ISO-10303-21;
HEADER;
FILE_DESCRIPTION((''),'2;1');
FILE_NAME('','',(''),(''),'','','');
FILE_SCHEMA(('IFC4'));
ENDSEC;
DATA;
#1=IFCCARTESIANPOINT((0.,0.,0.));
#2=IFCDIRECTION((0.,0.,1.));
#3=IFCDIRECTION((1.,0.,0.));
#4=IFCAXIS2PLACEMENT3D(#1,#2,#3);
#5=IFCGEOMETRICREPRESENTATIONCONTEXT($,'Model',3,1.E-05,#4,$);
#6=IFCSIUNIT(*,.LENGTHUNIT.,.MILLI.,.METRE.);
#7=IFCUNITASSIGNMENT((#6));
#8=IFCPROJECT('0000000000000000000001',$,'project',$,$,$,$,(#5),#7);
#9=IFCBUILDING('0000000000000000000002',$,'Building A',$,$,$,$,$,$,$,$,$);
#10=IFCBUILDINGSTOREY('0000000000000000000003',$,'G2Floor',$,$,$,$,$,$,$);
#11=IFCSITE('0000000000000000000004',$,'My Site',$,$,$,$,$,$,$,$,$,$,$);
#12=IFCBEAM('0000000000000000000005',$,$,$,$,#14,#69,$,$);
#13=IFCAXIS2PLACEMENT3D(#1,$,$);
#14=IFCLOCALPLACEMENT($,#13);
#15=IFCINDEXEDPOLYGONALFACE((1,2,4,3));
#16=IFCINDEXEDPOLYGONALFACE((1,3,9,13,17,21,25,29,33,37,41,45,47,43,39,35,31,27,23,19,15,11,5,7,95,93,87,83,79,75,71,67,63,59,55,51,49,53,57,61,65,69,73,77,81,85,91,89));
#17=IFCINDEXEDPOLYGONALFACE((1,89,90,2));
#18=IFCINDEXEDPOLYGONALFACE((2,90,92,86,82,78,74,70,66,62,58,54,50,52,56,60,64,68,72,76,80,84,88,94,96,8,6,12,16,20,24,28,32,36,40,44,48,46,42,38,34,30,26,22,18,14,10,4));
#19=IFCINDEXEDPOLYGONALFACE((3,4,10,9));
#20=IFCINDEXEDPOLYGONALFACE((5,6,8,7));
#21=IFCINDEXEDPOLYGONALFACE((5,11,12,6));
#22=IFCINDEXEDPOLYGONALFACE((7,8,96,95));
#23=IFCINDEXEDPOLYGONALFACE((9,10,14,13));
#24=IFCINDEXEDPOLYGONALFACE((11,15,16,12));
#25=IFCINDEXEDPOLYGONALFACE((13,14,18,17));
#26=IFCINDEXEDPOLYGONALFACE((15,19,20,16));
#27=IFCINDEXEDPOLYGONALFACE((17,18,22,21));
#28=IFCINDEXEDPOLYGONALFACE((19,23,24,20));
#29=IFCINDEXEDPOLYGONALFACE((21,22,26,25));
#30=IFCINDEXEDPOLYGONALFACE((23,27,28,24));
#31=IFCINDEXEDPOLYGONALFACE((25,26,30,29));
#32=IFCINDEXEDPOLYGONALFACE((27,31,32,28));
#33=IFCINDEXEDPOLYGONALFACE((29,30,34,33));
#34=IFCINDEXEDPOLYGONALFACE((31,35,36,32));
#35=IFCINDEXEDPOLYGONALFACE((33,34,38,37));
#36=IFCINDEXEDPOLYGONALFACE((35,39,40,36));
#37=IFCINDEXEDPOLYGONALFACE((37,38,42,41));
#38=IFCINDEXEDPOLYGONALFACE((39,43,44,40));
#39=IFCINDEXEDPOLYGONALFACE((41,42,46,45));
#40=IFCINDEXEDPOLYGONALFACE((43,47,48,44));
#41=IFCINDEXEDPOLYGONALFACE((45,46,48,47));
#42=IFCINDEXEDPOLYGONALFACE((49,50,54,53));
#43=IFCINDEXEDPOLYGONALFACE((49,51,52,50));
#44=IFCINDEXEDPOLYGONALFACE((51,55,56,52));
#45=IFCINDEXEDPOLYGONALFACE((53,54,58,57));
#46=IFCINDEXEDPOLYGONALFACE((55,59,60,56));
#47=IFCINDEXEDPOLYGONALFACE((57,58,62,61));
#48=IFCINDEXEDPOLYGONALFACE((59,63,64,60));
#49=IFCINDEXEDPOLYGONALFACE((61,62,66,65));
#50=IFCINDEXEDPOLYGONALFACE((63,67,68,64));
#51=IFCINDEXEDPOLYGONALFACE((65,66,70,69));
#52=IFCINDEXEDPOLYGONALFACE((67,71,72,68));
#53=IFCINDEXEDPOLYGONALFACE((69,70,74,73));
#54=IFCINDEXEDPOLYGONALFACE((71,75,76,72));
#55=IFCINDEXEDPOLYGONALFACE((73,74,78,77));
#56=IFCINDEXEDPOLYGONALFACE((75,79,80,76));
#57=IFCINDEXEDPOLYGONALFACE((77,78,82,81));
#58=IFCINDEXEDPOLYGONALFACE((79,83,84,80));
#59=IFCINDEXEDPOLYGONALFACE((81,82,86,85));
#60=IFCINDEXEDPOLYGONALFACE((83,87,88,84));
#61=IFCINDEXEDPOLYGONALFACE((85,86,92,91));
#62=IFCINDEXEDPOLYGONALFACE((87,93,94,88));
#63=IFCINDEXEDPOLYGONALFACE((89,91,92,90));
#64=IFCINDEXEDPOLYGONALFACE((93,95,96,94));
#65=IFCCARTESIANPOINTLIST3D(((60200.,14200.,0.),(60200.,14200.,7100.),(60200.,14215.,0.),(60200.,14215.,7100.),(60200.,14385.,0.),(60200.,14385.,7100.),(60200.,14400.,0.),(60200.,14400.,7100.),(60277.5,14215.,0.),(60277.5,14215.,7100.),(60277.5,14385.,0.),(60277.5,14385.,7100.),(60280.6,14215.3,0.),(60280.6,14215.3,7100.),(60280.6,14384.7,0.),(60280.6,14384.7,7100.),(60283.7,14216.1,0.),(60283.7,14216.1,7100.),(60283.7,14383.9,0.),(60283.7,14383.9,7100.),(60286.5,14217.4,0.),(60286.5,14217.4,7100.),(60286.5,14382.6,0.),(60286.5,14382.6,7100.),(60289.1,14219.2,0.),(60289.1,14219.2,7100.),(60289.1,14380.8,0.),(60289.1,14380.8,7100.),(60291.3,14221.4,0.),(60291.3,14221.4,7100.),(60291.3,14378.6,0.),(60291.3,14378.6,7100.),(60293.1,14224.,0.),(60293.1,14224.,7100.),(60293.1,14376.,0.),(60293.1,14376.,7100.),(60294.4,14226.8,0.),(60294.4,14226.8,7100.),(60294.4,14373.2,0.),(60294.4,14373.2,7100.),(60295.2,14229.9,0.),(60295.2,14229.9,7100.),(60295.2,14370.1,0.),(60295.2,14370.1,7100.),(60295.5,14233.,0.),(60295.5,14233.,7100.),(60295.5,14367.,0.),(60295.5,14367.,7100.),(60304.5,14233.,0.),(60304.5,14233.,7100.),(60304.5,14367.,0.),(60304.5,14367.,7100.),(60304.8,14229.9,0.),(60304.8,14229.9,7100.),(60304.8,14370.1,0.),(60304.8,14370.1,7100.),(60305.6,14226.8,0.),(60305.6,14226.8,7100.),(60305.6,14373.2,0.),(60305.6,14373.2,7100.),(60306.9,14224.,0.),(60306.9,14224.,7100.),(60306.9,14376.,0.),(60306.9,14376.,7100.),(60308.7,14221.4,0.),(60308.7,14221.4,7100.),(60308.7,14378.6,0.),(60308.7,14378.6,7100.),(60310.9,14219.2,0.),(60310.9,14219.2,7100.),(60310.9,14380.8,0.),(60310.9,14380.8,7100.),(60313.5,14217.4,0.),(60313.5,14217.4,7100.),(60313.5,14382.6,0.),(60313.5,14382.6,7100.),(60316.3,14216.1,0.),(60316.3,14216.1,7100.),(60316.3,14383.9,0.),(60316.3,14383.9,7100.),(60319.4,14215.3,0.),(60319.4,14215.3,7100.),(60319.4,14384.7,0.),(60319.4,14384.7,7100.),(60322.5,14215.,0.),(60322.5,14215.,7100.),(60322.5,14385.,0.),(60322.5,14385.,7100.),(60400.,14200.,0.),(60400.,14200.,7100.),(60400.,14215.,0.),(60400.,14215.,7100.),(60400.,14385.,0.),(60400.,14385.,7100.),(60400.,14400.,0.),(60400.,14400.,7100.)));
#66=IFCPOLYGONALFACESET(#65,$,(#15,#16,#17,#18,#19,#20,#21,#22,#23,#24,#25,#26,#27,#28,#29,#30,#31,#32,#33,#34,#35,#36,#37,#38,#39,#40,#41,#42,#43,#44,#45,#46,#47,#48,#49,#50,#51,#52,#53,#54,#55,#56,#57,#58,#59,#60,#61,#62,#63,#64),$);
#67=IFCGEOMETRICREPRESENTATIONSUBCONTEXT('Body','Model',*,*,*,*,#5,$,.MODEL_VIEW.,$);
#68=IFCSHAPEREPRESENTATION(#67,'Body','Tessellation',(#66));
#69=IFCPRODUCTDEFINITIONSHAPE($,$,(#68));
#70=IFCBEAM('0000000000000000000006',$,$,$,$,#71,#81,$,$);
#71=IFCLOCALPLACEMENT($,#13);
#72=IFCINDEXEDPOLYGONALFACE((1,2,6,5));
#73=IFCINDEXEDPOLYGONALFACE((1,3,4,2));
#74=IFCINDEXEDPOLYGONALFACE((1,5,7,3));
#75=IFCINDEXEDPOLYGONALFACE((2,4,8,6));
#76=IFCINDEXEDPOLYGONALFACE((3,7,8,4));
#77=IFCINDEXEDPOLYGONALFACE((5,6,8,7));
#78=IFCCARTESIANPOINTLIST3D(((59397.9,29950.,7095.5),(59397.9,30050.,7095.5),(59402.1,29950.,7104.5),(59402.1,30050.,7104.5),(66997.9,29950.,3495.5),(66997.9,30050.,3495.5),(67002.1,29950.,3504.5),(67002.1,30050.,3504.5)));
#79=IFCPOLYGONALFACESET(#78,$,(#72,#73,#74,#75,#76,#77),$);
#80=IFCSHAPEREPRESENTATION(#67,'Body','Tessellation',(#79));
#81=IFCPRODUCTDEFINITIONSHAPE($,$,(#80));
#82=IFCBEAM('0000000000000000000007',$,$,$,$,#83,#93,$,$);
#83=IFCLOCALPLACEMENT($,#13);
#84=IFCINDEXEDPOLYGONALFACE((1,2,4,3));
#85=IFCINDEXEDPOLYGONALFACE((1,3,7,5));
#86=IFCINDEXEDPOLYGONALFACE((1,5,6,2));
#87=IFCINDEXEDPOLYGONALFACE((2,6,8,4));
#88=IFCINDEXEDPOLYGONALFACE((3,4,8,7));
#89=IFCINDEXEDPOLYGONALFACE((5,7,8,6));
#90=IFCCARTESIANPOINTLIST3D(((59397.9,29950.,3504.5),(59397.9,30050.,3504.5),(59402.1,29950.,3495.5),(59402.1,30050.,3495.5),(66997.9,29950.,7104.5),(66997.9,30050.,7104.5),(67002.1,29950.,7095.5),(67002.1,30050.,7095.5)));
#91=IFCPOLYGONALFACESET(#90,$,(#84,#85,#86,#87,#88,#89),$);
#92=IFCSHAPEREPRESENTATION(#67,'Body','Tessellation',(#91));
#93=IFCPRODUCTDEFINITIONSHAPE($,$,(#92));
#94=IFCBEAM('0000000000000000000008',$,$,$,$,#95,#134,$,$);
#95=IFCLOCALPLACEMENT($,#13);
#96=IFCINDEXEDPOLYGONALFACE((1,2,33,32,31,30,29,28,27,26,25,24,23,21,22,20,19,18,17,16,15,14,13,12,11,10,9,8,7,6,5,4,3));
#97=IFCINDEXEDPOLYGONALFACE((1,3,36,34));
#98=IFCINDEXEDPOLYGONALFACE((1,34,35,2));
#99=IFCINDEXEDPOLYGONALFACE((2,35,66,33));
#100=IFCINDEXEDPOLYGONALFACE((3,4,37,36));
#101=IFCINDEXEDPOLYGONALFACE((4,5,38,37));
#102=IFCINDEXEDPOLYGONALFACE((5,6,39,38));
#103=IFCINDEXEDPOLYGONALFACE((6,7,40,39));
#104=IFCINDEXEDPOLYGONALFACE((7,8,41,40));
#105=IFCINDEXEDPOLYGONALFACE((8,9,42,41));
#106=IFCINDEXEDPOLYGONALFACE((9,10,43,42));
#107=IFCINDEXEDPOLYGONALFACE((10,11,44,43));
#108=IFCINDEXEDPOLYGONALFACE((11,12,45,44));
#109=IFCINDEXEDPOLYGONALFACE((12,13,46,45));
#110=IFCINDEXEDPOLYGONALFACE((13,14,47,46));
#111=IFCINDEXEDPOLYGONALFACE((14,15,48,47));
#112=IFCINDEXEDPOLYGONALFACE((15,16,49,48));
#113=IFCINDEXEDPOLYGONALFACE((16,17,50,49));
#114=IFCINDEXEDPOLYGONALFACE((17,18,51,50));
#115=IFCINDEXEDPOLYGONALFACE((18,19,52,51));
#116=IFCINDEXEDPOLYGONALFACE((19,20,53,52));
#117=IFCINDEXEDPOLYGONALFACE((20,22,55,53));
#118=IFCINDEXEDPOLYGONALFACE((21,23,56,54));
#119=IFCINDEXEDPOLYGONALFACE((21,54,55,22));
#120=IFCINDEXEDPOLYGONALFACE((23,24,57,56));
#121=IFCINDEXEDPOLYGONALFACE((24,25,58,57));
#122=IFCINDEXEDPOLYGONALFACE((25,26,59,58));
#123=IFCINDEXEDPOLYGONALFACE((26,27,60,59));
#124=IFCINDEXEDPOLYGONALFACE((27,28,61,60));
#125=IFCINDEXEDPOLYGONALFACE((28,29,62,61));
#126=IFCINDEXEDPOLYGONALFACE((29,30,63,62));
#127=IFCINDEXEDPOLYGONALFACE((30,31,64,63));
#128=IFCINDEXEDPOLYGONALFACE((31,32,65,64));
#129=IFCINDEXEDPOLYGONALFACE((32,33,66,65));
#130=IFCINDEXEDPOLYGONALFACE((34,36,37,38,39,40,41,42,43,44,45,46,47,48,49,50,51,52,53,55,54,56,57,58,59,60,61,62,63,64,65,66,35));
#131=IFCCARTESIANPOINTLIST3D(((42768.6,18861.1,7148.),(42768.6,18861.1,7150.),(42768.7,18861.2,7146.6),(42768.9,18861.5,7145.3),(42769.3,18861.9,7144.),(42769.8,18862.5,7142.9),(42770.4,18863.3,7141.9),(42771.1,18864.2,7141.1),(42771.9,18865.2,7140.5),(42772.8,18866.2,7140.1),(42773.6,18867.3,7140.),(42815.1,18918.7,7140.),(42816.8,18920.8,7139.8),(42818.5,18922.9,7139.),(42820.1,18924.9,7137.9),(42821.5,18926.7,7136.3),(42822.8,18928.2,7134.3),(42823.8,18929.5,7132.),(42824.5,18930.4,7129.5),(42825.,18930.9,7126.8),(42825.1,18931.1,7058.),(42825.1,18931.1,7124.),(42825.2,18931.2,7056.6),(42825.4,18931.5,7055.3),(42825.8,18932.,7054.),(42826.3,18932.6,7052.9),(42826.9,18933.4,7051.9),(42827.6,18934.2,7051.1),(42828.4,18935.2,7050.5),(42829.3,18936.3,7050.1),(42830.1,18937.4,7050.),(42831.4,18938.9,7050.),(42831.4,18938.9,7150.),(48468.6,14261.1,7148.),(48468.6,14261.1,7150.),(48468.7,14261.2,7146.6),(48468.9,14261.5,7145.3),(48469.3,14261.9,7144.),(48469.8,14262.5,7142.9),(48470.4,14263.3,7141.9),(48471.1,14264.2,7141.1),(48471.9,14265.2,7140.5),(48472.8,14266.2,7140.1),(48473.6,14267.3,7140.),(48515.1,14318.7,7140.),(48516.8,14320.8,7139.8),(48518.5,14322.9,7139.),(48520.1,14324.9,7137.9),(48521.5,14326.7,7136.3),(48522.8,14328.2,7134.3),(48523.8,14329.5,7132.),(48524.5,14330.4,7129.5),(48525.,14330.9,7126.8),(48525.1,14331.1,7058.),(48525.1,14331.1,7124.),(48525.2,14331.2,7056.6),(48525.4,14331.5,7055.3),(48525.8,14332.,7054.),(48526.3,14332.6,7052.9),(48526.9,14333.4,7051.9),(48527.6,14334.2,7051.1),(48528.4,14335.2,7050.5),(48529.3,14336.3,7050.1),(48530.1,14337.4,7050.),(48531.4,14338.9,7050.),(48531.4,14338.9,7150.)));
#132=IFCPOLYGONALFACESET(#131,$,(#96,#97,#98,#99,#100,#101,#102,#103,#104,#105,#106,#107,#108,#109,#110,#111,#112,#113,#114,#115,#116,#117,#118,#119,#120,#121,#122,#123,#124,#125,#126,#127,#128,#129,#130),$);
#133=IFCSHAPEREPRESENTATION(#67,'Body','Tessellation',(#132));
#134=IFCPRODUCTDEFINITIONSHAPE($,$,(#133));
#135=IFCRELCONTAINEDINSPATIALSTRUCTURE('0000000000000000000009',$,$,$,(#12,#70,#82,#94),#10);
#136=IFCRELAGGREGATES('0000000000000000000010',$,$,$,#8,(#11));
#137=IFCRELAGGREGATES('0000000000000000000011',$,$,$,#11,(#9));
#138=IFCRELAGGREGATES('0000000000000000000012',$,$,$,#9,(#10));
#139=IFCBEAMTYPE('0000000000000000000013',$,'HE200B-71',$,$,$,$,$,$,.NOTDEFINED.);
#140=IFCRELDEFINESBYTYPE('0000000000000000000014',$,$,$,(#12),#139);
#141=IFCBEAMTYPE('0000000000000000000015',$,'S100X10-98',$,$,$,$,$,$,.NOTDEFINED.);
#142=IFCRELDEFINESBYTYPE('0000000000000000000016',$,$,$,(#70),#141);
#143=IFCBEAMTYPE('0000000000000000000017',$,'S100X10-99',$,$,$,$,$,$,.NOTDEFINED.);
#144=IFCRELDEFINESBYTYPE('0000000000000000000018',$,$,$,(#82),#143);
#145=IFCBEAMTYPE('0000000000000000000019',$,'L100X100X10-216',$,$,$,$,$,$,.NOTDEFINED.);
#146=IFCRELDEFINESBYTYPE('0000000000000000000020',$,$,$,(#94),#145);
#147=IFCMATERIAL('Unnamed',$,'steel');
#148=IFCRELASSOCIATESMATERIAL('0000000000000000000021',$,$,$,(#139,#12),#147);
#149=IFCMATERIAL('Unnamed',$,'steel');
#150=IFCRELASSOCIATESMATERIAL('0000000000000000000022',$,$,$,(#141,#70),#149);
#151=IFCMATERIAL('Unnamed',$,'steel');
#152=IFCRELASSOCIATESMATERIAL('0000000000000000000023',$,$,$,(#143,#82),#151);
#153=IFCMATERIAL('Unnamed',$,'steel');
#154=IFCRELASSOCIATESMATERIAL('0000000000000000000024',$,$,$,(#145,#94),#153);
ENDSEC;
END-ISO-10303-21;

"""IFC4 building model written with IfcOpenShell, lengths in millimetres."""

from ifc_helpers import new_model, si_unit, frame, origin_with_axes, place, context, subcontext, project, spatial, polyline, outline, extrude, material, material_profile, profile_set, profile_usage, type_object, element, save


model = new_model("IFC4")

# Units and contexts
model_context = context("Model", 3, precision=1e-05, world=origin_with_axes())
body_context = subcontext(model_context, "Body", "Model", "MODEL_VIEW")
ifc_project = project(units=[si_unit("LENGTHUNIT", "METRE", prefix="MILLI")], contexts=[model_context])

# Site, building, storey
site = spatial("IfcSite", under=ifc_project, Name="My Site")
building = spatial("IfcBuilding", under=site, Name="Building A")
storey = spatial("IfcBuildingStorey", under=building, Name="G2Floor")

# Beams
ifc_material_1 = material(Name="Unnamed", Category="steel")
ifc_material_profile_1 = material_profile(ifc_material_1, outline(polyline([(100.0, -100.0), (100.0, -85.0), (100.0, -85.0), (22.5, -85.0), (22.5, -85.0), (19.4, -84.7), (19.4, -84.7), (16.3, -83.9), (16.3, -83.9), (13.5, -82.6), (13.5, -82.6), (10.9, -80.8), (10.9, -80.8), (8.7, -78.6), (8.7, -78.6), (6.9, -76.0), (6.9, -76.0), (5.6, -73.2), (5.6, -73.2), (4.8, -70.1), (4.8, -70.1), (4.5, -67.0), (4.5, -67.0), (4.5, 67.0), (4.5, 67.0), (4.8, 70.1), (4.8, 70.1), (5.6, 73.2), (5.6, 73.2), (6.9, 76.0), (6.9, 76.0), (8.7, 78.6), (8.7, 78.6), (10.9, 80.8), (10.9, 80.8), (13.5, 82.6), (13.5, 82.6), (16.3, 83.9), (16.3, 83.9), (19.4, 84.7), (19.4, 84.7), (22.5, 85.0), (22.5, 85.0), (100.0, 85.0), (100.0, 85.0), (100.0, 100.0), (100.0, 100.0), (-100.0, 100.0), (-100.0, 100.0), (-100.0, 85.0), (-100.0, 85.0), (-22.5, 85.0), (-22.5, 85.0), (-19.4, 84.7), (-19.4, 84.7), (-16.3, 83.9), (-16.3, 83.9), (-13.5, 82.6), (-13.5, 82.6), (-10.9, 80.8), (-10.9, 80.8), (-8.7, 78.6), (-8.7, 78.6), (-6.9, 76.0), (-6.9, 76.0), (-5.6, 73.2), (-5.6, 73.2), (-4.8, 70.1), (-4.8, 70.1), (-4.5, 67.0), (-4.5, 67.0), (-4.5, -67.0), (-4.5, -67.0), (-4.8, -70.1), (-4.8, -70.1), (-5.6, -73.2), (-5.6, -73.2), (-6.9, -76.0), (-6.9, -76.0), (-8.7, -78.6), (-8.7, -78.6), (-10.9, -80.8), (-10.9, -80.8), (-13.5, -82.6), (-13.5, -82.6), (-16.3, -83.9), (-16.3, -83.9), (-19.4, -84.7), (-19.4, -84.7), (-22.5, -85.0), (-22.5, -85.0), (-100.0, -85.0), (-100.0, -85.0), (-100.0, -100.0), (-100.0, -100.0), (100.0, -100.0)])))
ifc_profile_set_1 = profile_set([ifc_material_profile_1], Name="HE200B-71")
ifc_profile_usage_1 = profile_usage(ifc_profile_set_1)
beam_type_1 = type_object("IfcBeamType", Name="HE200B-71", PredefinedType="NOTDEFINED", material=ifc_profile_set_1)
beam_1_placement = place(None, frame((60300.0, 14300.0, 0.0), z_axis=(0.0, 0.0, 1.0), x_axis=(1.0, 0.0, 0.0)))
element("IfcBeam", 1, at=beam_1_placement, inside=storey, type_object=beam_type_1, material=ifc_profile_usage_1, context=body_context, shape_type="SweptSolid", body=[
    extrude(outline(polyline([(100.0, -100.0), (100.0, -85.0), (100.0, -85.0), (22.5, -85.0), (22.5, -85.0), (19.4, -84.7), (19.4, -84.7), (16.3, -83.9), (16.3, -83.9), (13.5, -82.6), (13.5, -82.6), (10.9, -80.8), (10.9, -80.8), (8.7, -78.6), (8.7, -78.6), (6.9, -76.0), (6.9, -76.0), (5.6, -73.2), (5.6, -73.2), (4.8, -70.1), (4.8, -70.1), (4.5, -67.0), (4.5, -67.0), (4.5, 67.0), (4.5, 67.0), (4.8, 70.1), (4.8, 70.1), (5.6, 73.2), (5.6, 73.2), (6.9, 76.0), (6.9, 76.0), (8.7, 78.6), (8.7, 78.6), (10.9, 80.8), (10.9, 80.8), (13.5, 82.6), (13.5, 82.6), (16.3, 83.9), (16.3, 83.9), (19.4, 84.7), (19.4, 84.7), (22.5, 85.0), (22.5, 85.0), (100.0, 85.0), (100.0, 85.0), (100.0, 100.0), (100.0, 100.0), (-100.0, 100.0), (-100.0, 100.0), (-100.0, 85.0), (-100.0, 85.0), (-22.5, 85.0), (-22.5, 85.0), (-19.4, 84.7), (-19.4, 84.7), (-16.3, 83.9), (-16.3, 83.9), (-13.5, 82.6), (-13.5, 82.6), (-10.9, 80.8), (-10.9, 80.8), (-8.7, 78.6), (-8.7, 78.6), (-6.9, 76.0), (-6.9, 76.0), (-5.6, 73.2), (-5.6, 73.2), (-4.8, 70.1), (-4.8, 70.1), (-4.5, 67.0), (-4.5, 67.0), (-4.5, -67.0), (-4.5, -67.0), (-4.8, -70.1), (-4.8, -70.1), (-5.6, -73.2), (-5.6, -73.2), (-6.9, -76.0), (-6.9, -76.0), (-8.7, -78.6), (-8.7, -78.6), (-10.9, -80.8), (-10.9, -80.8), (-13.5, -82.6), (-13.5, -82.6), (-16.3, -83.9), (-16.3, -83.9), (-19.4, -84.7), (-19.4, -84.7), (-22.5, -85.0), (-22.5, -85.0), (-100.0, -85.0), (-100.0, -85.0), (-100.0, -100.0), (-100.0, -100.0), (100.0, -100.0)])), origin_with_axes(), (0.0, 0.0, 1.0), 7100.0),
])
ifc_material_2 = material(Name="Unnamed", Category="steel")
ifc_material_profile_2 = material_profile(ifc_material_2, outline(polyline([(50.0, -5.0), (50.0, 5.0), (50.0, 5.0), (-50.0, 5.0), (-50.0, 5.0), (-50.0, -5.0), (-50.0, -5.0), (50.0, -5.0)])))
ifc_profile_set_2 = profile_set([ifc_material_profile_2], Name="S100X10-98")
ifc_profile_usage_2 = profile_usage(ifc_profile_set_2)
beam_type_2 = type_object("IfcBeamType", Name="S100X10-98", PredefinedType="NOTDEFINED", material=ifc_profile_set_2)
beam_2_placement = place(None, frame((59400.0, 30000.0, 7100.0), z_axis=(0.903738, 0.0, -0.428086), x_axis=(0.0, -1.0, 0.0)))
element("IfcBeam", 2, at=beam_2_placement, inside=storey, type_object=beam_type_2, material=ifc_profile_usage_2, context=body_context, shape_type="SweptSolid", body=[
    extrude(outline(polyline([(50.0, -5.0), (50.0, 5.0), (50.0, 5.0), (-50.0, 5.0), (-50.0, 5.0), (-50.0, -5.0), (-50.0, -5.0), (50.0, -5.0)])), origin_with_axes(), (0.0, 0.0, 1.0), 8409.5),
])
ifc_material_3 = material(Name="Unnamed", Category="steel")
ifc_material_profile_3 = material_profile(ifc_material_3, outline(polyline([(50.0, -5.0), (50.0, 5.0), (50.0, 5.0), (-50.0, 5.0), (-50.0, 5.0), (-50.0, -5.0), (-50.0, -5.0), (50.0, -5.0)])))
ifc_profile_set_3 = profile_set([ifc_material_profile_3], Name="S100X10-99")
ifc_profile_usage_3 = profile_usage(ifc_profile_set_3)
beam_type_3 = type_object("IfcBeamType", Name="S100X10-99", PredefinedType="NOTDEFINED", material=ifc_profile_set_3)
beam_3_placement = place(None, frame((59400.0, 30000.0, 3500.0), z_axis=(0.903738, 0.0, 0.428086), x_axis=(0.0, -1.0, 0.0)))
element("IfcBeam", 3, at=beam_3_placement, inside=storey, type_object=beam_type_3, material=ifc_profile_usage_3, context=body_context, shape_type="SweptSolid", body=[
    extrude(outline(polyline([(50.0, -5.0), (50.0, 5.0), (50.0, 5.0), (-50.0, 5.0), (-50.0, 5.0), (-50.0, -5.0), (-50.0, -5.0), (50.0, -5.0)])), origin_with_axes(), (0.0, 0.0, 1.0), 8409.5),
])
ifc_material_4 = material(Name="Unnamed", Category="steel")
ifc_material_profile_4 = material_profile(ifc_material_4, outline(polyline([(-50.0, -50.0), (50.0, -50.0), (50.0, -50.0), (50.0, -48.0), (50.0, -48.0), (49.9, -46.6), (49.9, -46.6), (49.5, -45.3), (49.5, -45.3), (48.9, -44.0), (48.9, -44.0), (48.1, -42.9), (48.1, -42.9), (47.1, -41.9), (47.1, -41.9), (46.0, -41.1), (46.0, -41.1), (44.7, -40.5), (44.7, -40.5), (43.4, -40.1), (43.4, -40.1), (42.0, -40.0), (42.0, -40.0), (-24.0, -40.0), (-24.0, -40.0), (-26.8, -39.8), (-26.8, -39.8), (-29.5, -39.0), (-29.5, -39.0), (-32.0, -37.9), (-32.0, -37.9), (-34.3, -36.3), (-34.3, -36.3), (-36.3, -34.3), (-36.3, -34.3), (-37.9, -32.0), (-37.9, -32.0), (-39.0, -29.5), (-39.0, -29.5), (-39.8, -26.8), (-39.8, -26.8), (-40.0, -24.0), (-40.0, -24.0), (-40.0, 42.0), (-40.0, 42.0), (-40.1, 43.4), (-40.1, 43.4), (-40.5, 44.7), (-40.5, 44.7), (-41.1, 46.0), (-41.1, 46.0), (-41.9, 47.1), (-41.9, 47.1), (-42.9, 48.1), (-42.9, 48.1), (-44.0, 48.9), (-44.0, 48.9), (-45.3, 49.5), (-45.3, 49.5), (-46.6, 49.9), (-46.6, 49.9), (-48.0, 50.0), (-48.0, 50.0), (-50.0, 50.0), (-50.0, 50.0), (-50.0, -50.0)])))
ifc_profile_set_4 = profile_set([ifc_material_profile_4], Name="L100X100X10-216")
ifc_profile_usage_4 = profile_usage(ifc_profile_set_4)
beam_type_4 = type_object("IfcBeamType", Name="L100X100X10-216", PredefinedType="NOTDEFINED", material=ifc_profile_set_4)
beam_4_placement = place(None, frame((42800.0, 18900.0, 7100.0), z_axis=(0.778198, -0.628019, 0.0), x_axis=(-0.628019, -0.778198, 0.0)))
element("IfcBeam", 4, at=beam_4_placement, inside=storey, type_object=beam_type_4, material=ifc_profile_usage_4, context=body_context, shape_type="SweptSolid", body=[
    extrude(outline(polyline([(-50.0, -50.0), (50.0, -50.0), (50.0, -50.0), (50.0, -48.0), (50.0, -48.0), (49.9, -46.6), (49.9, -46.6), (49.5, -45.3), (49.5, -45.3), (48.9, -44.0), (48.9, -44.0), (48.1, -42.9), (48.1, -42.9), (47.1, -41.9), (47.1, -41.9), (46.0, -41.1), (46.0, -41.1), (44.7, -40.5), (44.7, -40.5), (43.4, -40.1), (43.4, -40.1), (42.0, -40.0), (42.0, -40.0), (-24.0, -40.0), (-24.0, -40.0), (-26.8, -39.8), (-26.8, -39.8), (-29.5, -39.0), (-29.5, -39.0), (-32.0, -37.9), (-32.0, -37.9), (-34.3, -36.3), (-34.3, -36.3), (-36.3, -34.3), (-36.3, -34.3), (-37.9, -32.0), (-37.9, -32.0), (-39.0, -29.5), (-39.0, -29.5), (-39.8, -26.8), (-39.8, -26.8), (-40.0, -24.0), (-40.0, -24.0), (-40.0, 42.0), (-40.0, 42.0), (-40.1, 43.4), (-40.1, 43.4), (-40.5, 44.7), (-40.5, 44.7), (-41.1, 46.0), (-41.1, 46.0), (-41.9, 47.1), (-41.9, 47.1), (-42.9, 48.1), (-42.9, 48.1), (-44.0, 48.9), (-44.0, 48.9), (-45.3, 49.5), (-45.3, 49.5), (-46.6, 49.9), (-46.6, 49.9), (-48.0, 50.0), (-48.0, 50.0), (-50.0, 50.0), (-50.0, 50.0), (-50.0, -50.0)])), origin_with_axes(), (0.0, 0.0, 1.0), 7324.6),
])

save(model, "model.ifc")
